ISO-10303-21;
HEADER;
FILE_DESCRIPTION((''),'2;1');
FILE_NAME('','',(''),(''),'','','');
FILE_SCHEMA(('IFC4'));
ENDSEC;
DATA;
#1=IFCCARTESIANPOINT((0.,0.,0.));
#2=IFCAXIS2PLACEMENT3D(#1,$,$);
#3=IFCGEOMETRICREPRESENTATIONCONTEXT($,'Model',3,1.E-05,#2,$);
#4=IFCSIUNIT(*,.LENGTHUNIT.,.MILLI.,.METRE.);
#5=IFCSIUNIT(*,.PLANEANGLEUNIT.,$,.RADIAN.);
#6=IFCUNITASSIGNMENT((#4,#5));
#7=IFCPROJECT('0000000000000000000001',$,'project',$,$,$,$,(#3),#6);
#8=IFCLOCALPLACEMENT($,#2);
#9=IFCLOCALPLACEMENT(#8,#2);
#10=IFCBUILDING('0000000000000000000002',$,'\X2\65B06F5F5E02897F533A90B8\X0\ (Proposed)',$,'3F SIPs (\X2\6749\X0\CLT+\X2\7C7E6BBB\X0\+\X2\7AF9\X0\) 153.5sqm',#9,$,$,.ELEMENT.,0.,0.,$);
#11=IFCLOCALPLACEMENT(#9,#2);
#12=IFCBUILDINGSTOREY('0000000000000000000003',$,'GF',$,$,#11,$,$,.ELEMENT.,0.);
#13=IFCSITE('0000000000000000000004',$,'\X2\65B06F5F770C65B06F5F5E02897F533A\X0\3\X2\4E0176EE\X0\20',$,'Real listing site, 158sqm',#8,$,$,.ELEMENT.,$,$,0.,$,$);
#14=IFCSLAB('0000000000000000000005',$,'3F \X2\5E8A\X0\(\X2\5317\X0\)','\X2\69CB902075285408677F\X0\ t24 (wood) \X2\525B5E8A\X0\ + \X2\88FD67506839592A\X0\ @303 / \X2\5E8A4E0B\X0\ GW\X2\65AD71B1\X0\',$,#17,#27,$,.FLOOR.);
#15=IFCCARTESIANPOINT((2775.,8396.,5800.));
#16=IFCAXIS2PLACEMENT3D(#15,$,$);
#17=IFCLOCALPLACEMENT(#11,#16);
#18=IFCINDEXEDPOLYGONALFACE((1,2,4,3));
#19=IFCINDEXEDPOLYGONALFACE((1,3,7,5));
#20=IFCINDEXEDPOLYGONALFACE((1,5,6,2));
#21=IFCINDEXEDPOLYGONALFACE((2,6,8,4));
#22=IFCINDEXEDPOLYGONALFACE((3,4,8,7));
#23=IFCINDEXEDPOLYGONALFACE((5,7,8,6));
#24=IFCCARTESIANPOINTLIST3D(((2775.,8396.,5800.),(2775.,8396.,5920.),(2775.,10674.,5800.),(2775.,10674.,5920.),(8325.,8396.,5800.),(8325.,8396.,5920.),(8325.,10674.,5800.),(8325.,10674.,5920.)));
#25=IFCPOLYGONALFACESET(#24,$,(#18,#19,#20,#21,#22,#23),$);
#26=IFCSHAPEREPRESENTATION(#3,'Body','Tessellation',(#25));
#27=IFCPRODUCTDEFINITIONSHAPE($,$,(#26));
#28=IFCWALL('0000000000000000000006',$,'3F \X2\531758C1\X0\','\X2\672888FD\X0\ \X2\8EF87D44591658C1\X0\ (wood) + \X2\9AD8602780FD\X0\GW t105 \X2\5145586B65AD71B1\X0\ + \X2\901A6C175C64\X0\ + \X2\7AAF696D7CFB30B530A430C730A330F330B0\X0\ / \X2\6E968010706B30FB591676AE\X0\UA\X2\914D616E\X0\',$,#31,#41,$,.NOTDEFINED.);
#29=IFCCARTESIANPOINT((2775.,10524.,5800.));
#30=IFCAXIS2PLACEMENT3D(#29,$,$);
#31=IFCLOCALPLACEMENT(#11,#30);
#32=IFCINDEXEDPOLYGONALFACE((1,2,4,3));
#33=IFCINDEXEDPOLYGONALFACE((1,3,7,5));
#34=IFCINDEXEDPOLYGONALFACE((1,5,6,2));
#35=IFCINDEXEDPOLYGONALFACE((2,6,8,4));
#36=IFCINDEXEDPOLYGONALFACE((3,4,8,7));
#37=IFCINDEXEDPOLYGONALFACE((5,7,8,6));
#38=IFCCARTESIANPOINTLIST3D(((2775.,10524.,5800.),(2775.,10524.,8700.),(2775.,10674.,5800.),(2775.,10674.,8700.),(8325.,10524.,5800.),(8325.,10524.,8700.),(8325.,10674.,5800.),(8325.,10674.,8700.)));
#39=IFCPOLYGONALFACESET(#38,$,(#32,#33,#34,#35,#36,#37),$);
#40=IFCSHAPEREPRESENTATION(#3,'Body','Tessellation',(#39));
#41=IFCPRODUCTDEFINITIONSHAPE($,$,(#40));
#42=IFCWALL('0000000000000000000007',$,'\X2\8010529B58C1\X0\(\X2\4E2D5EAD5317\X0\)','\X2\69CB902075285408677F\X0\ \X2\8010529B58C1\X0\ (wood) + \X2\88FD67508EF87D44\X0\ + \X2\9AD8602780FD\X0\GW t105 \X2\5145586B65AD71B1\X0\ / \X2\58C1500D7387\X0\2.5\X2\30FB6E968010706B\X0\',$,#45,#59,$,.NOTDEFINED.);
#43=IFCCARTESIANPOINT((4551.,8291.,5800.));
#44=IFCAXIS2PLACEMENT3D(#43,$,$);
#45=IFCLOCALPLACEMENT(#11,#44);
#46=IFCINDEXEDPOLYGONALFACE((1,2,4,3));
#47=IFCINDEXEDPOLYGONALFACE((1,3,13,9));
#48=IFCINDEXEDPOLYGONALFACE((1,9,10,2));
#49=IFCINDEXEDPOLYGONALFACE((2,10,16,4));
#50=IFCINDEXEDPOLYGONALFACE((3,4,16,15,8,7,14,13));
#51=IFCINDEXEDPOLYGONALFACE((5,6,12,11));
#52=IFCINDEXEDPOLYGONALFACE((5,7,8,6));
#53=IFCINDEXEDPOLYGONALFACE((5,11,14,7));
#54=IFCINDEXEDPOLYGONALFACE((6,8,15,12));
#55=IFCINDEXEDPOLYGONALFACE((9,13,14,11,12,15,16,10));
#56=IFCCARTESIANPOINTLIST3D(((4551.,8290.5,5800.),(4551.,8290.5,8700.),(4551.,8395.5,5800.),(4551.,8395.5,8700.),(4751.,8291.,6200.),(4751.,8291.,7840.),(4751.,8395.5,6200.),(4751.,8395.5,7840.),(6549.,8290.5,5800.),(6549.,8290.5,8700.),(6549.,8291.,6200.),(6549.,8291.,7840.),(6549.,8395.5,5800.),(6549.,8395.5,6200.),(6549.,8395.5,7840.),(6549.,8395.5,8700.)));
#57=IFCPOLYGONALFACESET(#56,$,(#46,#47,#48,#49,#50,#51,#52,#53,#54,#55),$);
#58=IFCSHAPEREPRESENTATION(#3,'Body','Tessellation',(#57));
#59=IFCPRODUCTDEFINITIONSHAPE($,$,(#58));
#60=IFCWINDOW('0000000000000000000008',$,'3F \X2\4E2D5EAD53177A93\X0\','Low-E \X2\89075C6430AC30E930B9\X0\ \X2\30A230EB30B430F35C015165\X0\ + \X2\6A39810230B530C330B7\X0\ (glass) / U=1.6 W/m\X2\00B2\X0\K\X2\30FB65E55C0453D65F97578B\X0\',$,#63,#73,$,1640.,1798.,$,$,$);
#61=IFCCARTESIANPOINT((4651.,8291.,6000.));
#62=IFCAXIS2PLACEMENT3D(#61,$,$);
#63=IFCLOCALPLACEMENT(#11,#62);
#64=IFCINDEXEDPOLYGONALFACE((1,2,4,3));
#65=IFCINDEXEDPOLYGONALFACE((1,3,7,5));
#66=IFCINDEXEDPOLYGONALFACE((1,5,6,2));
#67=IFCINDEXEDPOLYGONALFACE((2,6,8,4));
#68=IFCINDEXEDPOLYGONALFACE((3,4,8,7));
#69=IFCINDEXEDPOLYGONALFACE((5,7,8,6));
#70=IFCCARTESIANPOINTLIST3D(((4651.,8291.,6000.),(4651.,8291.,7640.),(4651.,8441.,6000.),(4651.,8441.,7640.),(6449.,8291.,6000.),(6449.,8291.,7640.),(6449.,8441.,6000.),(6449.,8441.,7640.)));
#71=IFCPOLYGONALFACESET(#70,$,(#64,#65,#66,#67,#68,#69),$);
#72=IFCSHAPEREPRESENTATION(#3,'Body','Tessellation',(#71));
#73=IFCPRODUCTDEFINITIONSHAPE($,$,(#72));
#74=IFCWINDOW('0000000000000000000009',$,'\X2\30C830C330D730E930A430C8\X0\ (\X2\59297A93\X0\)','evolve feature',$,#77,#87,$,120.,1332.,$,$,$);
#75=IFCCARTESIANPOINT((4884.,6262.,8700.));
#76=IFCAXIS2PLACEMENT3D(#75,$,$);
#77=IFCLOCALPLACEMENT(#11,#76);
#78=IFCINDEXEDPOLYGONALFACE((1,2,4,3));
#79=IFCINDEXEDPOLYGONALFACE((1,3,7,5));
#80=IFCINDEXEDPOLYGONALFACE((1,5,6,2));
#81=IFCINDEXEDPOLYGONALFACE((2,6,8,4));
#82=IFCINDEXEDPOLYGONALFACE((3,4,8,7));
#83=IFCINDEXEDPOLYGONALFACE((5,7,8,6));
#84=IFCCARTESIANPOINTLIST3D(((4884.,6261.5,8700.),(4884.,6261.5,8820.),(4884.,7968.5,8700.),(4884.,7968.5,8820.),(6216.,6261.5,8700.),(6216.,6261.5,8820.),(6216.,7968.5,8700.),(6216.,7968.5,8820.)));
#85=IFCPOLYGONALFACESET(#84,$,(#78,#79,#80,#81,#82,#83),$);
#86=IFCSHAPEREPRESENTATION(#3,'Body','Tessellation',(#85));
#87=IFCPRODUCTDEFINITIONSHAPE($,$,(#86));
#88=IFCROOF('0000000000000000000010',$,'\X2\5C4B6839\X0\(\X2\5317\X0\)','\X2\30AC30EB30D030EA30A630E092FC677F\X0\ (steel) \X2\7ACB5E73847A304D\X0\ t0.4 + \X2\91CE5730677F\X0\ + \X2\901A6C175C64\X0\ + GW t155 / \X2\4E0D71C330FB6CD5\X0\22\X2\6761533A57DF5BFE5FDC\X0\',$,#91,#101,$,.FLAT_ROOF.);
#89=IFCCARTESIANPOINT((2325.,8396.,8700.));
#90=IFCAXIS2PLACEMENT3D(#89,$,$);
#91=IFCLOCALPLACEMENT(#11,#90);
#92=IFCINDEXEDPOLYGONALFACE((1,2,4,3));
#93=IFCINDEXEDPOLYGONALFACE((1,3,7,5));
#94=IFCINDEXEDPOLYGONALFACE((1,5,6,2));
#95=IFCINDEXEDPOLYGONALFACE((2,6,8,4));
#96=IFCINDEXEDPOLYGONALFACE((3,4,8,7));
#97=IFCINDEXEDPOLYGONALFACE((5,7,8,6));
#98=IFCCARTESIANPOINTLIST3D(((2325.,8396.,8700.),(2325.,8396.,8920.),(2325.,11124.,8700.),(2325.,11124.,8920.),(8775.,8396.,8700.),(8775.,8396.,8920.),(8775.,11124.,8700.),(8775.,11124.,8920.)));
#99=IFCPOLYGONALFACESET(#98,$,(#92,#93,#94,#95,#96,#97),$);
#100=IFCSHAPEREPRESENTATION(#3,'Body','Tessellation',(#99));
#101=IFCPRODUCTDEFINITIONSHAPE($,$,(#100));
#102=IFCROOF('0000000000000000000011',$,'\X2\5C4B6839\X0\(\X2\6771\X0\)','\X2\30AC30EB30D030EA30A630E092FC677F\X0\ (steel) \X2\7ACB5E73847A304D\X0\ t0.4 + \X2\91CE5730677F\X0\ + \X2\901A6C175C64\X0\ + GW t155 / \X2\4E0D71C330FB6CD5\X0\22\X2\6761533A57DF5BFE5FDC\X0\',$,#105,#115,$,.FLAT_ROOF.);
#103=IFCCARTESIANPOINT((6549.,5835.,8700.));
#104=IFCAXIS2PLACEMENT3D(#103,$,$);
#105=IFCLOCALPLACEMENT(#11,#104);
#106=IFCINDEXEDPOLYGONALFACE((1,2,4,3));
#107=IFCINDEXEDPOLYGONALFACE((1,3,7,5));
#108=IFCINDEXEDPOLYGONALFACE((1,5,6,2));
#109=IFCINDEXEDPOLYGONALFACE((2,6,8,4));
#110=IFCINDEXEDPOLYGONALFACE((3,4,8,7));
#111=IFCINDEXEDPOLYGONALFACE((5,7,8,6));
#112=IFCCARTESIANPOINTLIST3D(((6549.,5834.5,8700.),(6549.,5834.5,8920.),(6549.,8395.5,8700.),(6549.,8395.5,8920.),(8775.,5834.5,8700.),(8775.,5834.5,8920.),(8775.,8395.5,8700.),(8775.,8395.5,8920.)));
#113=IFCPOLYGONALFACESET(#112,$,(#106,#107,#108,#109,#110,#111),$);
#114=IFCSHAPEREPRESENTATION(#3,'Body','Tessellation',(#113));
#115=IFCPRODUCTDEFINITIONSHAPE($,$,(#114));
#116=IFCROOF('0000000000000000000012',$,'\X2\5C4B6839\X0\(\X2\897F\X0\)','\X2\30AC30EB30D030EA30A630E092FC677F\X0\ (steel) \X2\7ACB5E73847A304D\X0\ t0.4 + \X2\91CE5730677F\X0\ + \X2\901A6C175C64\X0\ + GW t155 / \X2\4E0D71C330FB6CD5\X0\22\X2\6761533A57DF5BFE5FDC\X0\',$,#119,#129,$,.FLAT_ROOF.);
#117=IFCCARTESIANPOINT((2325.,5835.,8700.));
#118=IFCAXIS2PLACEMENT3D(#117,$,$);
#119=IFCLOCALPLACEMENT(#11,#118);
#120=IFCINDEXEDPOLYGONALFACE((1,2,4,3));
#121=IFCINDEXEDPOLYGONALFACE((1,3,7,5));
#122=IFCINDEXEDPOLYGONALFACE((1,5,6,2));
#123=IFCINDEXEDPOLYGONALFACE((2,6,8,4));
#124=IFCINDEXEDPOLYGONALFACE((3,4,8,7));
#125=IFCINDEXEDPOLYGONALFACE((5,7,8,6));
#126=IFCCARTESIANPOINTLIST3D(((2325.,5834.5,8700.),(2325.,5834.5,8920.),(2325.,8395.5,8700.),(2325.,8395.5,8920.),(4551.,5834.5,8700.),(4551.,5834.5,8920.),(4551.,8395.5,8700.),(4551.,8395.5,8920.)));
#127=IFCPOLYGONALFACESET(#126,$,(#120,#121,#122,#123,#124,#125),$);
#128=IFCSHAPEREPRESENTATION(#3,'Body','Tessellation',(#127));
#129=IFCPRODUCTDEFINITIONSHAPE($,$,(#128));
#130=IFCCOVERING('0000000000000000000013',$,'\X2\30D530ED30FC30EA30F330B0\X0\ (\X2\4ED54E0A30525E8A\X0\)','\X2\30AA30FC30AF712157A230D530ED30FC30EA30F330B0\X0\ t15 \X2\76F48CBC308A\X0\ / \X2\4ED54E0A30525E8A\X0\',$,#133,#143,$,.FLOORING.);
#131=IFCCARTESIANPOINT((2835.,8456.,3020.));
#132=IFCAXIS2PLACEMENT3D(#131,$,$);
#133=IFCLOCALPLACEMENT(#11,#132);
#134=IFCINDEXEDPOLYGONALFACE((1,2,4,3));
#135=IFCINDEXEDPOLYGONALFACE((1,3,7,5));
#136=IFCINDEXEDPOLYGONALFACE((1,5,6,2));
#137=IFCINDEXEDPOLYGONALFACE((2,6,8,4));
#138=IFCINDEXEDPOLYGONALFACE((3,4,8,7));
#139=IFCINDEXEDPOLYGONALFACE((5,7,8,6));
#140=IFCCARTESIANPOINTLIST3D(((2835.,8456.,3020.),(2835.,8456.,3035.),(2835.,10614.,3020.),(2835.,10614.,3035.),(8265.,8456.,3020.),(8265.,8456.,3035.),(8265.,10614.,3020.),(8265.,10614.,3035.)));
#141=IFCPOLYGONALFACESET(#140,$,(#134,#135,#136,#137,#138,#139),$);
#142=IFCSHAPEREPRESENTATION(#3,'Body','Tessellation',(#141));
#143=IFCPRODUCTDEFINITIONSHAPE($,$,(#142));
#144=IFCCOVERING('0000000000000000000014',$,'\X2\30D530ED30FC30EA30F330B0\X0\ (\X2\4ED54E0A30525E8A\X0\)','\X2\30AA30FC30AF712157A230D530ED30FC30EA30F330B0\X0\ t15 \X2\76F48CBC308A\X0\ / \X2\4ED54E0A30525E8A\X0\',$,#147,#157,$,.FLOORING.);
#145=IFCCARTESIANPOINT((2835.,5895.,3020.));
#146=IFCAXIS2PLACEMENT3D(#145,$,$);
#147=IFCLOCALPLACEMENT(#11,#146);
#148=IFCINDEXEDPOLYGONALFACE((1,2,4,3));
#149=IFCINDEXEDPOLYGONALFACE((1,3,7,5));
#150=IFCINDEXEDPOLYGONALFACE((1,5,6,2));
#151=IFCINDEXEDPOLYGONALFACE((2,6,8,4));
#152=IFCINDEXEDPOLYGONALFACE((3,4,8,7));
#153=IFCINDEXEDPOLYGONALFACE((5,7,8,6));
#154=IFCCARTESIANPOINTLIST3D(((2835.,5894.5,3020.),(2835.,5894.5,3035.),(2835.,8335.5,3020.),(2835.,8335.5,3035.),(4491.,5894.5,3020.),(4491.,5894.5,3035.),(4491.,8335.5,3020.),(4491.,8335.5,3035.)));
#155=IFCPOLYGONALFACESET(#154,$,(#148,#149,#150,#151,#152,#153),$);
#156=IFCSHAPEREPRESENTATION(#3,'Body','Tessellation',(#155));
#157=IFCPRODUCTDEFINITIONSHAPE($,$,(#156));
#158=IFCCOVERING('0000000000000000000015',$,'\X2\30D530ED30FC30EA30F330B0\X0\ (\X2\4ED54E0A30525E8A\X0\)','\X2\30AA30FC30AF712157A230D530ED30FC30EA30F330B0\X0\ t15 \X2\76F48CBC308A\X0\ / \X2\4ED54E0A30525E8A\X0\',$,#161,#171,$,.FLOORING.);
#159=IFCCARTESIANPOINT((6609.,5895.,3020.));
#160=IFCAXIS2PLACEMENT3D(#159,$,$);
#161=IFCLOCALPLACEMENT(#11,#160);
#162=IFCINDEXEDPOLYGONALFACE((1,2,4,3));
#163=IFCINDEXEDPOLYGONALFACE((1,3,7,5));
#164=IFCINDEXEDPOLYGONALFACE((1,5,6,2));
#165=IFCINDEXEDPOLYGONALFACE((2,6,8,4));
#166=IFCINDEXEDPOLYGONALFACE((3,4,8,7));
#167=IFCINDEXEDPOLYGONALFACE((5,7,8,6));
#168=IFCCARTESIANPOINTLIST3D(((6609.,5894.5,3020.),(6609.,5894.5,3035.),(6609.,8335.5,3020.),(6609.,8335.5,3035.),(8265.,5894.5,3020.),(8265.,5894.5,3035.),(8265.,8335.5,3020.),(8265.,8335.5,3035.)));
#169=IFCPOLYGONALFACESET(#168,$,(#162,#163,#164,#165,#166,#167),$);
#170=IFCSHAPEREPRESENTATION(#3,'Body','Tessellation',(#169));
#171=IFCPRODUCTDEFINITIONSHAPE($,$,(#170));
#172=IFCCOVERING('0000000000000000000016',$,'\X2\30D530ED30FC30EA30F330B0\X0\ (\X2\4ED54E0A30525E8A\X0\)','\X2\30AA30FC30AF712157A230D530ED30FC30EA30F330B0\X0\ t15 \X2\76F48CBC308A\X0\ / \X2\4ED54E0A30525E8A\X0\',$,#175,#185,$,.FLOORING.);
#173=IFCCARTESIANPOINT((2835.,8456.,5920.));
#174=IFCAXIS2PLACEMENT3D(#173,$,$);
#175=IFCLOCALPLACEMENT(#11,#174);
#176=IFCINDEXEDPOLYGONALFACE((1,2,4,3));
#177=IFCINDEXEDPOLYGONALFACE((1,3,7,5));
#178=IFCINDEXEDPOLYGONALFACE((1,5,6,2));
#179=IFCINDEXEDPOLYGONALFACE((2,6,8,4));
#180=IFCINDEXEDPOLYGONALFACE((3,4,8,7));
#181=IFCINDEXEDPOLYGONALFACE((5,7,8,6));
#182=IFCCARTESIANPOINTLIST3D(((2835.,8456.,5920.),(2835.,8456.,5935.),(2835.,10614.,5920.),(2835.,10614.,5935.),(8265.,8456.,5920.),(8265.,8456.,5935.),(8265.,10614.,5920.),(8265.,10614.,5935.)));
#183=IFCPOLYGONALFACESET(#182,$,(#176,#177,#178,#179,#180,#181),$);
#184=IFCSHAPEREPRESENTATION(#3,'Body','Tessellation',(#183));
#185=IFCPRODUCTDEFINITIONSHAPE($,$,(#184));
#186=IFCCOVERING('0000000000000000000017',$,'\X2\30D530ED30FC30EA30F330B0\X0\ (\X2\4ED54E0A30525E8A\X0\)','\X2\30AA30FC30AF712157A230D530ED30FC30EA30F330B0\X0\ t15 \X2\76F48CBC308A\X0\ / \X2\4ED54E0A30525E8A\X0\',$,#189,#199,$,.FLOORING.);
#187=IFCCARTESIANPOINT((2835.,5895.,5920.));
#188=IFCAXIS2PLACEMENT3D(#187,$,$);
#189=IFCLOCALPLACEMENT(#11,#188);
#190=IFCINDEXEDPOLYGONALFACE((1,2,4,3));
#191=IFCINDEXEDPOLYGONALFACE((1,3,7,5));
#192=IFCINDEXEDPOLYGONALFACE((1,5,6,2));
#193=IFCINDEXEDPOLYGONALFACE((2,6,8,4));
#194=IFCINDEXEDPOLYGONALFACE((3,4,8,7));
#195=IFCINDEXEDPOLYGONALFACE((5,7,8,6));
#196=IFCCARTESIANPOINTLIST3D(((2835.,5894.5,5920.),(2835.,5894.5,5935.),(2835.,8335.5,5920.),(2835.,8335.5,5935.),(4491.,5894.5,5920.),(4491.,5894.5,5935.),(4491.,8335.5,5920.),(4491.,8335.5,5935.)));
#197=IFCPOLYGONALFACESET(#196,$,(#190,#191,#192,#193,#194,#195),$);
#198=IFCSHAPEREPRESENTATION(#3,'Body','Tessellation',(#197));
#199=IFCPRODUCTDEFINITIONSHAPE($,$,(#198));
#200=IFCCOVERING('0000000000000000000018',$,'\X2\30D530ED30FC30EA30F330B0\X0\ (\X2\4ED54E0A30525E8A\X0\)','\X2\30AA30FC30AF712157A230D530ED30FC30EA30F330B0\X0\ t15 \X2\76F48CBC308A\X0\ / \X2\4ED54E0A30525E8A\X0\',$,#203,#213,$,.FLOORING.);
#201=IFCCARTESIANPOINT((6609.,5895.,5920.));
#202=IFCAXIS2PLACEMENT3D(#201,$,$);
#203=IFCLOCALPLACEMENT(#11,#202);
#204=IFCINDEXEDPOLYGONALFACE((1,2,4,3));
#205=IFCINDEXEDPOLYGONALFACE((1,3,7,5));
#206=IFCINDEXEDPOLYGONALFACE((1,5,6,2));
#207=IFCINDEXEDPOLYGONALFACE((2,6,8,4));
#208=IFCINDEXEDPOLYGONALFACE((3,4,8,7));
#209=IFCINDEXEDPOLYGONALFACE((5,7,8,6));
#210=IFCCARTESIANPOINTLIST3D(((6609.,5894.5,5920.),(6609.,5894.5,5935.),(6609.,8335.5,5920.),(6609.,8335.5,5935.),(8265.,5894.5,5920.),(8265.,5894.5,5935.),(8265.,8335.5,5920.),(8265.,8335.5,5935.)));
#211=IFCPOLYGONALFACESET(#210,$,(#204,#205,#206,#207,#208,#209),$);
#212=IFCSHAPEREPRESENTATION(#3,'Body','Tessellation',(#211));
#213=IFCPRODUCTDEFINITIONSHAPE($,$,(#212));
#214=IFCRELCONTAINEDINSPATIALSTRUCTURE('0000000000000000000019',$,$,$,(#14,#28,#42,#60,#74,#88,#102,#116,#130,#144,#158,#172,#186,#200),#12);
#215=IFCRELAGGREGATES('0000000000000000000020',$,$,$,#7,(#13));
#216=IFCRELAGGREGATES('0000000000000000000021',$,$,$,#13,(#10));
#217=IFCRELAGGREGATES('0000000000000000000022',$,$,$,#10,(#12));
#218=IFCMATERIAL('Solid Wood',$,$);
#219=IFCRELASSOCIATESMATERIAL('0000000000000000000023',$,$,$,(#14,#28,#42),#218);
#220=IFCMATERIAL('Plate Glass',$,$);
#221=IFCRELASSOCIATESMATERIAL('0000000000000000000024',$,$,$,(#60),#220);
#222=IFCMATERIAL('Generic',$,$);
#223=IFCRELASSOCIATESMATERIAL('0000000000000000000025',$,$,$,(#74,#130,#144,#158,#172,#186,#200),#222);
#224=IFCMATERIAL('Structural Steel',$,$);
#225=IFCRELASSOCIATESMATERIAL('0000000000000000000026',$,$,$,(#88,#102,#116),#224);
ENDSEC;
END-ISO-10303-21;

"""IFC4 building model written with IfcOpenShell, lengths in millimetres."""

from ifc_helpers import new_model, si_unit, frame, frame_2d, origin, place, context, project, spatial, rectangle, extrude, material, element, fill, save


model = new_model("IFC4")

# Units and contexts
model_context = context("Model", 3, precision=1e-05, world=origin())
ifc_project = project(units=[si_unit("LENGTHUNIT", "METRE", prefix="MILLI"), si_unit("PLANEANGLEUNIT", "RADIAN")], contexts=[model_context])

# Site, building, storey
site_placement = place(None, origin())
site = spatial("IfcSite", under=ifc_project, at=site_placement, Name="新潟県新潟市西区3丁目20", ObjectType="Real listing site, 158sqm", CompositionType="ELEMENT", RefElevation=0.0)
building_placement = place(site_placement, origin())
building = spatial("IfcBuilding", under=site, at=building_placement, Name="新潟市西区邸 (Proposed)", ObjectType="3F SIPs (杉CLT+籾殻+竹) 153.5sqm", CompositionType="ELEMENT", ElevationOfRefHeight=0.0, ElevationOfTerrain=0.0)
storey_placement = place(building_placement, origin())
storey = spatial("IfcBuildingStorey", under=building, at=storey_placement, Name="GF", CompositionType="ELEMENT", Elevation=0.0)

# Slab
ifc_material_1 = material(Name="Solid Wood")
slab_placement = place(storey_placement, frame((2775.0, 8396.0, 5800.0)))
element("IfcSlab", 1, at=slab_placement, inside=storey, material=ifc_material_1, Name="3F 床(北)", Description="構造用合板 t24 (wood) 剛床 + 製材根太 @303 / 床下 GW断熱", PredefinedType="FLOOR", context=model_context, shape_type="SweptSolid", body=[
    extrude(rectangle(XDim=5550.0, YDim=2278.0, at=frame_2d((2775.0, 1139.0))), frame((2775.0, 8396.0, 5800.0)), (0.0, 0.0, 1.0), 120.0),
])

# Wall
wall_1_placement = place(storey_placement, frame((2775.0, 10524.0, 5800.0)))
element("IfcWall", 2, at=wall_1_placement, inside=storey, material=ifc_material_1, Name="3F 北壁", Description="木製 軸組外壁 (wood) + 高性能GW t105 充填断熱 + 通気層 + 窯業系サイディング / 準耐火・外皮UA配慮", PredefinedType="NOTDEFINED", context=model_context, shape_type="SweptSolid", body=[
    extrude(rectangle(XDim=5550.0, YDim=150.0, at=frame_2d((2775.0, 75.0))), frame((2775.0, 10524.0, 5800.0)), (0.0, 0.0, 1.0), 2900.0),
])

# Wall, opening, window
wall_2_placement = place(storey_placement, frame((4551.0, 8291.0, 5800.0)))
wall_2 = element("IfcWall", 3, at=wall_2_placement, inside=storey, material=ifc_material_1, Name="耐力壁(中庭北)", Description="構造用合板 耐力壁 (wood) + 製材軸組 + 高性能GW t105 充填断熱 / 壁倍率2.5・準耐火", PredefinedType="NOTDEFINED", context=model_context, shape_type="SweptSolid", body=[
    extrude(rectangle(XDim=1998.0, YDim=105.0, at=frame_2d((999.0, 52.0))), frame((4551.0, 8291.0, 5800.0)), (0.0, 0.0, 1.0), 2900.0),
])
opening_placement = place(storey_placement, frame((4651.0, 8291.0, 6000.0)))
opening = element("IfcOpeningElement", 4, at=opening_placement, cuts=wall_2, PredefinedType="NOTDEFINED", context=model_context, shape_type="SweptSolid", body=[
    extrude(rectangle(XDim=1798.0, YDim=150.0, at=frame_2d((899.0, 75.0))), frame((4651.0, 8291.0, 6000.0)), (0.0, 0.0, 1.0), 1640.0),
])
ifc_material_2 = material(Name="Plate Glass")
window_1_placement = place(storey_placement, frame((4651.0, 8291.0, 6000.0)))
window_1 = element("IfcWindow", 5, at=window_1_placement, inside=storey, material=ifc_material_2, Name="3F 中庭北窓", Description="Low-E 複層ガラス アルゴン封入 + 樹脂サッシ (glass) / U=1.6 W/m²K・日射取得型", OverallHeight=1640.0, OverallWidth=1798.0, context=model_context, shape_type="SweptSolid", body=[
    extrude(rectangle(XDim=1798.0, YDim=150.0, at=frame_2d((899.0, 75.0))), frame((4651.0, 8291.0, 6000.0)), (0.0, 0.0, 1.0), 1640.0),
])
fill(opening, window_1)

# Window
ifc_material_3 = material(Name="Generic")
window_2_placement = place(storey_placement, frame((4884.0, 6262.0, 8700.0)))
element("IfcWindow", 6, at=window_2_placement, inside=storey, material=ifc_material_3, Name="トップライト (天窓)", Description="evolve feature", OverallHeight=120.0, OverallWidth=1332.0, context=model_context, shape_type="SweptSolid", body=[
    extrude(rectangle(XDim=1332.0, YDim=1707.0, at=frame_2d((666.0, 853.0))), frame((4884.0, 6262.0, 8700.0)), (0.0, 0.0, 1.0), 120.0),
])

# Roofs
ifc_material_4 = material(Name="Structural Steel")
roof_1_placement = place(storey_placement, frame((2325.0, 8396.0, 8700.0)))
element("IfcRoof", 7, at=roof_1_placement, inside=storey, material=ifc_material_4, Name="屋根(北)", Description="ガルバリウム鋼板 (steel) 立平葺き t0.4 + 野地板 + 通気層 + GW t155 / 不燃・法22条区域対応", PredefinedType="FLAT_ROOF", context=model_context, shape_type="SweptSolid", body=[
    extrude(rectangle(XDim=6450.0, YDim=2728.0, at=frame_2d((3225.0, 1364.0))), frame((2325.0, 8396.0, 8700.0)), (0.0, 0.0, 1.0), 220.0),
])
roof_2_placement = place(storey_placement, frame((6549.0, 5835.0, 8700.0)))
element("IfcRoof", 8, at=roof_2_placement, inside=storey, material=ifc_material_4, Name="屋根(東)", Description="ガルバリウム鋼板 (steel) 立平葺き t0.4 + 野地板 + 通気層 + GW t155 / 不燃・法22条区域対応", PredefinedType="FLAT_ROOF", context=model_context, shape_type="SweptSolid", body=[
    extrude(rectangle(XDim=2226.0, YDim=2561.0, at=frame_2d((1113.0, 1280.0))), frame((6549.0, 5835.0, 8700.0)), (0.0, 0.0, 1.0), 220.0),
])
roof_3_placement = place(storey_placement, frame((2325.0, 5835.0, 8700.0)))
element("IfcRoof", 9, at=roof_3_placement, inside=storey, material=ifc_material_4, Name="屋根(西)", Description="ガルバリウム鋼板 (steel) 立平葺き t0.4 + 野地板 + 通気層 + GW t155 / 不燃・法22条区域対応", PredefinedType="FLAT_ROOF", context=model_context, shape_type="SweptSolid", body=[
    extrude(rectangle(XDim=2226.0, YDim=2561.0, at=frame_2d((1113.0, 1280.0))), frame((2325.0, 5835.0, 8700.0)), (0.0, 0.0, 1.0), 220.0),
])

# Coverings
covering_1_placement = place(storey_placement, frame((2835.0, 8456.0, 3020.0)))
element("IfcCovering", 10, at=covering_1_placement, inside=storey, material=ifc_material_3, Name="フローリング (仕上げ床)", Description="オーク無垢フローリング t15 直貼り / 仕上げ床", PredefinedType="FLOORING", context=model_context, shape_type="SweptSolid", body=[
    extrude(rectangle(XDim=5430.0, YDim=2158.0, at=frame_2d((2715.0, 1079.0))), frame((2835.0, 8456.0, 3020.0)), (0.0, 0.0, 1.0), 15.0),
])
covering_2_placement = place(storey_placement, frame((2835.0, 5895.0, 3020.0)))
element("IfcCovering", 11, at=covering_2_placement, inside=storey, material=ifc_material_3, Name="フローリング (仕上げ床)", Description="オーク無垢フローリング t15 直貼り / 仕上げ床", PredefinedType="FLOORING", context=model_context, shape_type="SweptSolid", body=[
    extrude(rectangle(XDim=1656.0, YDim=2441.0, at=frame_2d((828.0, 1220.0))), frame((2835.0, 5895.0, 3020.0)), (0.0, 0.0, 1.0), 15.0),
])
covering_3_placement = place(storey_placement, frame((6609.0, 5895.0, 3020.0)))
element("IfcCovering", 12, at=covering_3_placement, inside=storey, material=ifc_material_3, Name="フローリング (仕上げ床)", Description="オーク無垢フローリング t15 直貼り / 仕上げ床", PredefinedType="FLOORING", context=model_context, shape_type="SweptSolid", body=[
    extrude(rectangle(XDim=1656.0, YDim=2441.0, at=frame_2d((828.0, 1220.0))), frame((6609.0, 5895.0, 3020.0)), (0.0, 0.0, 1.0), 15.0),
])
covering_4_placement = place(storey_placement, frame((2835.0, 8456.0, 5920.0)))
element("IfcCovering", 13, at=covering_4_placement, inside=storey, material=ifc_material_3, Name="フローリング (仕上げ床)", Description="オーク無垢フローリング t15 直貼り / 仕上げ床", PredefinedType="FLOORING", context=model_context, shape_type="SweptSolid", body=[
    extrude(rectangle(XDim=5430.0, YDim=2158.0, at=frame_2d((2715.0, 1079.0))), frame((2835.0, 8456.0, 5920.0)), (0.0, 0.0, 1.0), 15.0),
])
covering_5_placement = place(storey_placement, frame((2835.0, 5895.0, 5920.0)))
element("IfcCovering", 14, at=covering_5_placement, inside=storey, material=ifc_material_3, Name="フローリング (仕上げ床)", Description="オーク無垢フローリング t15 直貼り / 仕上げ床", PredefinedType="FLOORING", context=model_context, shape_type="SweptSolid", body=[
    extrude(rectangle(XDim=1656.0, YDim=2441.0, at=frame_2d((828.0, 1220.0))), frame((2835.0, 5895.0, 5920.0)), (0.0, 0.0, 1.0), 15.0),
])
covering_6_placement = place(storey_placement, frame((6609.0, 5895.0, 5920.0)))
element("IfcCovering", 15, at=covering_6_placement, inside=storey, material=ifc_material_3, Name="フローリング (仕上げ床)", Description="オーク無垢フローリング t15 直貼り / 仕上げ床", PredefinedType="FLOORING", context=model_context, shape_type="SweptSolid", body=[
    extrude(rectangle(XDim=1656.0, YDim=2441.0, at=frame_2d((828.0, 1220.0))), frame((6609.0, 5895.0, 5920.0)), (0.0, 0.0, 1.0), 15.0),
])

save(model, "model.ifc")
